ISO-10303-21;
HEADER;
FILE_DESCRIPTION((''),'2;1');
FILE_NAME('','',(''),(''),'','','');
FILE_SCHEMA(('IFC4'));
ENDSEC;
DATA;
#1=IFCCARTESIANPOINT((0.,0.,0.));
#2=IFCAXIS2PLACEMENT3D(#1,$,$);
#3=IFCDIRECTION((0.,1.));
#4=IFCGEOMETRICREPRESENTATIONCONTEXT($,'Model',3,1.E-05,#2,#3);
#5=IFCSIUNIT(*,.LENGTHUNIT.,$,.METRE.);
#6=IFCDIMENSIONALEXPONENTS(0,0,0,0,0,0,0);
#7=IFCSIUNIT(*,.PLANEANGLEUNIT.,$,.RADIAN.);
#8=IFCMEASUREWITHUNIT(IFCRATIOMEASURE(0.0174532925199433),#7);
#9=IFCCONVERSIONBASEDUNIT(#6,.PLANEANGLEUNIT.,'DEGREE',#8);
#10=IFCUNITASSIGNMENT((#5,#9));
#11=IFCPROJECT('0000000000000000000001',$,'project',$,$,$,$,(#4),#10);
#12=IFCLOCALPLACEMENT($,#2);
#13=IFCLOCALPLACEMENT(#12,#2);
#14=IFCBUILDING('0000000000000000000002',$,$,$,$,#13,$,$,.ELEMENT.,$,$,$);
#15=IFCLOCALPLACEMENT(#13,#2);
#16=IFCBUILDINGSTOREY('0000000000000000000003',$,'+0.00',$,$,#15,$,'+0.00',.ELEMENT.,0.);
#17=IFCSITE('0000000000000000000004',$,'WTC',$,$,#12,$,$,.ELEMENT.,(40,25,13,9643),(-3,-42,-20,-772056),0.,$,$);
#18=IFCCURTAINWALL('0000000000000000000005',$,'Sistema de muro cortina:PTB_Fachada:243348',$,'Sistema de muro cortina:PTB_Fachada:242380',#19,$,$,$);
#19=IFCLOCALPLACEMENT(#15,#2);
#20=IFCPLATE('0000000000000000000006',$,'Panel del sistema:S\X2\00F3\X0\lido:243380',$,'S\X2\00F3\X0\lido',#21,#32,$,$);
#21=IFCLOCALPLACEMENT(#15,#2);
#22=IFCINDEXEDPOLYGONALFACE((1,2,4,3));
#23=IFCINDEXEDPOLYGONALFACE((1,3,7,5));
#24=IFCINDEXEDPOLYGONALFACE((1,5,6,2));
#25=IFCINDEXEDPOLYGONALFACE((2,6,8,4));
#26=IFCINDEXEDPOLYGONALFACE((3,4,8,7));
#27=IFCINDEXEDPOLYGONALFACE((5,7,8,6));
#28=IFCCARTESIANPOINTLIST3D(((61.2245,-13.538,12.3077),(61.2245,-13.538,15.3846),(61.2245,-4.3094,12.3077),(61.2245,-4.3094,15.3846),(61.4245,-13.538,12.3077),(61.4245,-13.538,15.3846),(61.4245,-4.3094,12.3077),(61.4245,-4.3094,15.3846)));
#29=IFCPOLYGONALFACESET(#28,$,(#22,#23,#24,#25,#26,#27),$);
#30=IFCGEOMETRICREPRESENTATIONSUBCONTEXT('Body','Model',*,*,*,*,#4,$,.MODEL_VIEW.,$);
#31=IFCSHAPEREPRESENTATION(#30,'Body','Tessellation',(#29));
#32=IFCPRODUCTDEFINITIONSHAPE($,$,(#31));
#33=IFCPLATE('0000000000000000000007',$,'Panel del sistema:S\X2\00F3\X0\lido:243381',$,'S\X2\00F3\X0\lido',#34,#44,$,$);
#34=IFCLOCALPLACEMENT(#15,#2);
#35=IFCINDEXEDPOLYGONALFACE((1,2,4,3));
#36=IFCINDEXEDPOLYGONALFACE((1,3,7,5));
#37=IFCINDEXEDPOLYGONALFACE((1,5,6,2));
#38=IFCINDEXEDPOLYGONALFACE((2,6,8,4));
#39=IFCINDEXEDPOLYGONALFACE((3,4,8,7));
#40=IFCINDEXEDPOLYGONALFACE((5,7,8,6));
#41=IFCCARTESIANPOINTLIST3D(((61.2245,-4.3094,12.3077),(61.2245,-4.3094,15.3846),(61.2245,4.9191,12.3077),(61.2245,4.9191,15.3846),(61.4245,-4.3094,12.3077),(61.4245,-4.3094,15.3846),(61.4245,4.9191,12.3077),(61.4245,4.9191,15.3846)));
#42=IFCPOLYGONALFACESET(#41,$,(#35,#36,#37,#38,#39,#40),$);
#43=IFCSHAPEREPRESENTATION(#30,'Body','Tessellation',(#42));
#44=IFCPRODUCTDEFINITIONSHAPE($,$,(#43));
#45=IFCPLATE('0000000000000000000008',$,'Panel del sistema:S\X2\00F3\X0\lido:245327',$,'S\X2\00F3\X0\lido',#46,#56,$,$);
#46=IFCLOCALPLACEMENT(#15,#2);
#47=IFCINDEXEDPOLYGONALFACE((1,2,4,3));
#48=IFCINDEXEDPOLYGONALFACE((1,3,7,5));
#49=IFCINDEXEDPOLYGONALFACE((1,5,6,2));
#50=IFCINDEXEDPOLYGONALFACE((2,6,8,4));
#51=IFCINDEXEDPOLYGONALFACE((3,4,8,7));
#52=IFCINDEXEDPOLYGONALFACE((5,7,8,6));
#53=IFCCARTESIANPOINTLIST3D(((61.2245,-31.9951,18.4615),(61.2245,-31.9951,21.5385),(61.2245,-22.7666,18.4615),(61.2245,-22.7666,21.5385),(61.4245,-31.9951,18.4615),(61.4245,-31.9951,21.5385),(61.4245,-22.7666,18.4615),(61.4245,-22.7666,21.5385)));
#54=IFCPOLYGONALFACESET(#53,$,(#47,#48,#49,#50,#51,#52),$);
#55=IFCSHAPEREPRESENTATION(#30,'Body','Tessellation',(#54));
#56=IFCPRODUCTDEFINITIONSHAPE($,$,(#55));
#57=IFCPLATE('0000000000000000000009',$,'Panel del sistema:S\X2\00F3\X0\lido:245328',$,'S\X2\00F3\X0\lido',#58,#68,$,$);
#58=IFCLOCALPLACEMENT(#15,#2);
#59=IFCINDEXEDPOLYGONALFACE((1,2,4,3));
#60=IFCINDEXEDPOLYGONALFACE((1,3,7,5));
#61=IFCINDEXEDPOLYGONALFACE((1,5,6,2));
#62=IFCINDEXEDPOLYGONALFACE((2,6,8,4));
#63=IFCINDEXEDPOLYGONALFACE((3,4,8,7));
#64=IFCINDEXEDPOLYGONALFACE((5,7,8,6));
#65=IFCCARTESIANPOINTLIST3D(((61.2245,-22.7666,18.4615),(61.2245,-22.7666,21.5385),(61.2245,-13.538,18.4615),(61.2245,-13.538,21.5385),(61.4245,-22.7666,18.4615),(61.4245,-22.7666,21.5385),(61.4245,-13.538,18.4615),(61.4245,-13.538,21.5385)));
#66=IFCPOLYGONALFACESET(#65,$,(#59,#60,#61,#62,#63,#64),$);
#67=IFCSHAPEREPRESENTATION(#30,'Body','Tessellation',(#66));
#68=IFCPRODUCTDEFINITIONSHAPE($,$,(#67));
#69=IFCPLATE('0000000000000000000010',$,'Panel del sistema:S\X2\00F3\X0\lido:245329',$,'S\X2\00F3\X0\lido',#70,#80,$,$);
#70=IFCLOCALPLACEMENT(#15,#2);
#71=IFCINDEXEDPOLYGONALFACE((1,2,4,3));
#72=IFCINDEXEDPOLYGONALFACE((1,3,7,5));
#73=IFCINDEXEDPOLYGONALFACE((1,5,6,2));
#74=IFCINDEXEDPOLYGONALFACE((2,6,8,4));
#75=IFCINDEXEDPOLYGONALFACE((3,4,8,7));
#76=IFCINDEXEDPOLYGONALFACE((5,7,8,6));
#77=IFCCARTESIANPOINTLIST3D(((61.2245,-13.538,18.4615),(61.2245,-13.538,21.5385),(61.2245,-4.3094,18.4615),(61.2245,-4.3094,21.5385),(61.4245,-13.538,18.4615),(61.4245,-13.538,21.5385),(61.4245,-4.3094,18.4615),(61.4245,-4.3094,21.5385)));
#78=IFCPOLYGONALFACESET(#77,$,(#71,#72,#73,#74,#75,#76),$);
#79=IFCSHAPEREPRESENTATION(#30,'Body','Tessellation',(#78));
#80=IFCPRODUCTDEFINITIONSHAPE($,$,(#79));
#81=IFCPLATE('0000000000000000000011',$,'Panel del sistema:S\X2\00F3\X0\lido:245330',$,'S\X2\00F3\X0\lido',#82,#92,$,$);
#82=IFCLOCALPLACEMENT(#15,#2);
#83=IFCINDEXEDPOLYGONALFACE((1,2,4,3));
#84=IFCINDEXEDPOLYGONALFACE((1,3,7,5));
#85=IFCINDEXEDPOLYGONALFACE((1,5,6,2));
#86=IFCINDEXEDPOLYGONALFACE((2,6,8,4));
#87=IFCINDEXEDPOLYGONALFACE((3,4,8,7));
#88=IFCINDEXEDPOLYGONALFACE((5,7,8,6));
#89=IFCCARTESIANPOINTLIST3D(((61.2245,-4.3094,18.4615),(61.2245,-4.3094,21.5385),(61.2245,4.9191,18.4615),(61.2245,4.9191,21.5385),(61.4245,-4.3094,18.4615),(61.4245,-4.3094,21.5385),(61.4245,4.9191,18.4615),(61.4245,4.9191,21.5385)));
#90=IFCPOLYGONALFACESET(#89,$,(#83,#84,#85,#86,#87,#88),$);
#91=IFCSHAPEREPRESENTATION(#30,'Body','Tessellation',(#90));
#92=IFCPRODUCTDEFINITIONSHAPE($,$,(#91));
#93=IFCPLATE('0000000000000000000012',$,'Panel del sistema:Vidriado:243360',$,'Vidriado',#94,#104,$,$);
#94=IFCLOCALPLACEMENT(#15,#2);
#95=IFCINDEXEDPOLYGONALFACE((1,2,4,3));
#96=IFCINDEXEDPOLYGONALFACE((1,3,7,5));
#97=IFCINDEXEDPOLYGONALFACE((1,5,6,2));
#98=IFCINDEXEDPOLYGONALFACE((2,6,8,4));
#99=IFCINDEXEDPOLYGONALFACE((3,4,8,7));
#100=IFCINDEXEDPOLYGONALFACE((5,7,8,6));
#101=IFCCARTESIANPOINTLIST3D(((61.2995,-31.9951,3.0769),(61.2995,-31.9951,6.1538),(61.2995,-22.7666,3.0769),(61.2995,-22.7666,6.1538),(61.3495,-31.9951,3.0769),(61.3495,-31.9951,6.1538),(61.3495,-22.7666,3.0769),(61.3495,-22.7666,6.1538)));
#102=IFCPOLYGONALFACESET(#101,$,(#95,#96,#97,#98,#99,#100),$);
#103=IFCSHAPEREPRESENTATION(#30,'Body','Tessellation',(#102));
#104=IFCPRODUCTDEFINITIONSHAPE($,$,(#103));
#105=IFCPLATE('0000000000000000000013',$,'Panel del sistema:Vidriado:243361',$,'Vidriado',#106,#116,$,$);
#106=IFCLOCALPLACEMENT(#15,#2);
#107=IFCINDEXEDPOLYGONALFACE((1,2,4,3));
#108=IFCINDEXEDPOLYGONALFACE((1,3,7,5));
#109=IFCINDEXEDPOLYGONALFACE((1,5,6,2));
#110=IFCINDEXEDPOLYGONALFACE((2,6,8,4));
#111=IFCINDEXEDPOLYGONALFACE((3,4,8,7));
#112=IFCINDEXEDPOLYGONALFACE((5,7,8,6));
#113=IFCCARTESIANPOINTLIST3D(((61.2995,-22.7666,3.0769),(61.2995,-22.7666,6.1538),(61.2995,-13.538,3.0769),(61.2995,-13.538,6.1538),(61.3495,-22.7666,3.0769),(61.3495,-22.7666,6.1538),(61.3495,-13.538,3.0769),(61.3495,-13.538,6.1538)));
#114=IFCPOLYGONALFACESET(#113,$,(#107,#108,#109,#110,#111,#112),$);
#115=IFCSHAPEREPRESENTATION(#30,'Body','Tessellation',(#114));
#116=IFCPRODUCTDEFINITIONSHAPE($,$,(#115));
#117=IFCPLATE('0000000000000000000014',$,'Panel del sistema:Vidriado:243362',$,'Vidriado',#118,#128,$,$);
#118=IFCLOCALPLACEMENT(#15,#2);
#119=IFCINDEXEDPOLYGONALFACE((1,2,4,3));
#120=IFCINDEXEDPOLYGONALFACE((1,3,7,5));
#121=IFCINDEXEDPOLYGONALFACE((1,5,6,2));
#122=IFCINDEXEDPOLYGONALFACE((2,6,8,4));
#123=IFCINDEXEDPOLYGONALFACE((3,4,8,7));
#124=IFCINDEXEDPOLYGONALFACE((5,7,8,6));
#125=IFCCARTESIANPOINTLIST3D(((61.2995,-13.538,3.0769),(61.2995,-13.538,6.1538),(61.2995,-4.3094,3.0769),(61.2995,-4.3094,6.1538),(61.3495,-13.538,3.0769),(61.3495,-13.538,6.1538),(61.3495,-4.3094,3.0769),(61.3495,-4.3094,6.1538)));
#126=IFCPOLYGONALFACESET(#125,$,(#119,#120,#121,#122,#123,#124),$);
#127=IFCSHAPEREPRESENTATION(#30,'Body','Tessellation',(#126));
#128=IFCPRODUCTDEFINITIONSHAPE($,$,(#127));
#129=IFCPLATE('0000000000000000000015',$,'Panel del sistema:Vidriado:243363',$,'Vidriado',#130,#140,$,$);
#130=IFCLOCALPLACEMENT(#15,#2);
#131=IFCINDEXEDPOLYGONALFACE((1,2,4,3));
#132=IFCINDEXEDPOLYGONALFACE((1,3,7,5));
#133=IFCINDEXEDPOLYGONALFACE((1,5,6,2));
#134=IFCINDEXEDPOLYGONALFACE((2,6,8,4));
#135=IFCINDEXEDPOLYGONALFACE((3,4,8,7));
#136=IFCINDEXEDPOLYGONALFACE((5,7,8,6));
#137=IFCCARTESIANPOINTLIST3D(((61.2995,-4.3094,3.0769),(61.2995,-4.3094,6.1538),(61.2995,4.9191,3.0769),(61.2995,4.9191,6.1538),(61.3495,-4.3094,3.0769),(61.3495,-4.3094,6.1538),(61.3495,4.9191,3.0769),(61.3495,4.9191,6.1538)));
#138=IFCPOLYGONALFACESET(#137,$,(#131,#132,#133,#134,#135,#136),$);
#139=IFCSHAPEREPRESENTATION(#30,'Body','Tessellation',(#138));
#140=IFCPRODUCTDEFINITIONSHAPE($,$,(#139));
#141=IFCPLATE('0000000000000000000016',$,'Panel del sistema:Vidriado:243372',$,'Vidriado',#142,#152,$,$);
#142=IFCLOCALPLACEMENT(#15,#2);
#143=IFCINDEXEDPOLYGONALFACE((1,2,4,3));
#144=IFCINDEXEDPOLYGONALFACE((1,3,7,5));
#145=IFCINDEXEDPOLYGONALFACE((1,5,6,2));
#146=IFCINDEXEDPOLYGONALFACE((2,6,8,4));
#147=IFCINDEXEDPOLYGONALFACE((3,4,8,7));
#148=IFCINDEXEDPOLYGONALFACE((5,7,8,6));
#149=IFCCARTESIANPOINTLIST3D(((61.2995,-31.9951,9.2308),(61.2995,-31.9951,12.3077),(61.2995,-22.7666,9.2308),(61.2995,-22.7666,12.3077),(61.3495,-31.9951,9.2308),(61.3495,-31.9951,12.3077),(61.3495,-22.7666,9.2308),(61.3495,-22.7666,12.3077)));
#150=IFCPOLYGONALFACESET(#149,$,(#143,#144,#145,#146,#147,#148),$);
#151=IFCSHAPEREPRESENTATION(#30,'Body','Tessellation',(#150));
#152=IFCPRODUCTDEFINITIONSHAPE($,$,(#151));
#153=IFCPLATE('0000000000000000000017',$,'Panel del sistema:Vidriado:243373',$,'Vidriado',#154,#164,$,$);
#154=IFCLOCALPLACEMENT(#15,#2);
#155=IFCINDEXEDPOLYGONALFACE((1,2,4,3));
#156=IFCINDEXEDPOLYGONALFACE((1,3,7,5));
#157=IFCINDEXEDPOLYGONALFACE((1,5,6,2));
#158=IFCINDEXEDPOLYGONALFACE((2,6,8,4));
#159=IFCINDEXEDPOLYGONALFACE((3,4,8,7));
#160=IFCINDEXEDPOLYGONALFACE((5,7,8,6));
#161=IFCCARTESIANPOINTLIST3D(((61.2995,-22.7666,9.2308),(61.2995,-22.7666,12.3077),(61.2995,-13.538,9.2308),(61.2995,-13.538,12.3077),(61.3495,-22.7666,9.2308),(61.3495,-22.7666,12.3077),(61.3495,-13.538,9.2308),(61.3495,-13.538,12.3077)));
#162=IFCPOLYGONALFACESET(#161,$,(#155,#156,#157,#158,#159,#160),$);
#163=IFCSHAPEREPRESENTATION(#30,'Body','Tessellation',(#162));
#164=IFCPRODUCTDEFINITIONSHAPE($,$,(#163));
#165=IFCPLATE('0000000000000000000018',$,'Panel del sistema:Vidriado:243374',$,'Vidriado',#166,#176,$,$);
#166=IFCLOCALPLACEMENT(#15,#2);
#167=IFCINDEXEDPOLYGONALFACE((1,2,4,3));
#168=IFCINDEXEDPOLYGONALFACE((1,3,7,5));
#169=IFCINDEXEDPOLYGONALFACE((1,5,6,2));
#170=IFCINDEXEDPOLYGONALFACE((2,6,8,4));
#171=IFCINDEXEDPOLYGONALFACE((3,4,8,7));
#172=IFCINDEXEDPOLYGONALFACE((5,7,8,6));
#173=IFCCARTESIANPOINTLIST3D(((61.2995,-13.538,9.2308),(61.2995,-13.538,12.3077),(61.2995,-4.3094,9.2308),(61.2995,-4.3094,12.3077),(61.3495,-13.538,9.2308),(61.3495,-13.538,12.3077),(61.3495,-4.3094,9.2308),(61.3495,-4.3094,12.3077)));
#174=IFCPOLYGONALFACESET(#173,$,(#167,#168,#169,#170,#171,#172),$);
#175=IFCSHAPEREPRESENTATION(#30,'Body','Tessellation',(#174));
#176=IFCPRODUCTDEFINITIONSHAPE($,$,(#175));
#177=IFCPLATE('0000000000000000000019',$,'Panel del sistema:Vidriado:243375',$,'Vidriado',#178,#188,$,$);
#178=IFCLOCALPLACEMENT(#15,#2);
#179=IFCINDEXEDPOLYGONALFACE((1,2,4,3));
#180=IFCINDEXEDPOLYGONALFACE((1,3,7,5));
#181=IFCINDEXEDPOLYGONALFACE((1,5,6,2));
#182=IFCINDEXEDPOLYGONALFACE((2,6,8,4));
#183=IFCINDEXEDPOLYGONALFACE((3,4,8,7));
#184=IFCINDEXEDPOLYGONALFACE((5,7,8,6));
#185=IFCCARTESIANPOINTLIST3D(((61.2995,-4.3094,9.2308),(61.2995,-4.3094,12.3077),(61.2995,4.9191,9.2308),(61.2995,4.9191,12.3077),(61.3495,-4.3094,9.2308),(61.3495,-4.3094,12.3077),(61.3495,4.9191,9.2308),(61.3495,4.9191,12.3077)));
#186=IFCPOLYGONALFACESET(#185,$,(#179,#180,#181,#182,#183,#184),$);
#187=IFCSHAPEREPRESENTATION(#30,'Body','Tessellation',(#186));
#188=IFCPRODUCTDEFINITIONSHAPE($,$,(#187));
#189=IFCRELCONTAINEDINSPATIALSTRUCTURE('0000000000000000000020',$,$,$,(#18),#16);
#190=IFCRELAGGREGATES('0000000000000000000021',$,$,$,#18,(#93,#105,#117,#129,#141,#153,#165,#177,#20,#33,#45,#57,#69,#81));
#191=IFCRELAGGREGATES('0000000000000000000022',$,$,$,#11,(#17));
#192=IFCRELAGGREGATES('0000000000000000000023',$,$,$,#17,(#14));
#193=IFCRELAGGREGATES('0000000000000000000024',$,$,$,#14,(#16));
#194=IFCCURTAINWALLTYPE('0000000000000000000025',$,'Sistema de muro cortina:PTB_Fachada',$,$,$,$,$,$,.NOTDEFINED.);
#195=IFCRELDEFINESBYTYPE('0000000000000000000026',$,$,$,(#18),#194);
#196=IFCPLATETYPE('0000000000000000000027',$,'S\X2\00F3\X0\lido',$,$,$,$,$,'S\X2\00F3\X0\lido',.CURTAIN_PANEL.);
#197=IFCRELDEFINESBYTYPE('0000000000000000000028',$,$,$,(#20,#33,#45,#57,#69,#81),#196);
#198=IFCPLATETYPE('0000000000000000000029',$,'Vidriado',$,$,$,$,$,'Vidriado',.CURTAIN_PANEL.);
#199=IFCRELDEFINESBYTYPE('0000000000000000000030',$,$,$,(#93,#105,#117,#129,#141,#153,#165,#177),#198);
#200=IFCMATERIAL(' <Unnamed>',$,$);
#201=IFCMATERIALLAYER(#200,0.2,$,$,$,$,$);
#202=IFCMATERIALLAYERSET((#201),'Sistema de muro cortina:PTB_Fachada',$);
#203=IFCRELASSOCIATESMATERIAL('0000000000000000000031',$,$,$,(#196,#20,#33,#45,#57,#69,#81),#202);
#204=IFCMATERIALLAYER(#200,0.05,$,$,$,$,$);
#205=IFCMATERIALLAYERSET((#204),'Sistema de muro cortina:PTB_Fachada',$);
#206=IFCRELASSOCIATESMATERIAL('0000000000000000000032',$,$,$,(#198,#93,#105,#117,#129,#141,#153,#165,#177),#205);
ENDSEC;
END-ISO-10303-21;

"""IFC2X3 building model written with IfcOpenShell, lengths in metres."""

from ifc_helpers import new_model, entity, si_unit, converted_unit, direction, frame, frame_2d, origin, origin_2d_with_axis, place, context, subcontext, project, spatial, rectangle, extrude, source, transform, mapped, material, layer, layer_set, layer_usage, type_object, type_shapes, element, aggregate, save


model = new_model("IFC2X3")

# Units and contexts
model_context = context("Model", 3, precision=1e-05, world=origin(), true_north=direction((0.0, 1.0)))
body_context = subcontext(model_context, "Body", "Model", "MODEL_VIEW")
ifc_project = project(units=[si_unit("LENGTHUNIT", "METRE"), converted_unit("PLANEANGLEUNIT", "DEGREE", entity("IfcRatioMeasure", 0.0174532925199433), si_unit("PLANEANGLEUNIT", "RADIAN"), dimensions=[0, 0, 0, 0, 0, 0, 0])], contexts=[model_context])

# Site, building, storey
site_placement = place(None, origin())
site = spatial("IfcSite", under=ifc_project, at=site_placement, Name="WTC", CompositionType="ELEMENT", RefLatitude=(40, 25, 13, 9643), RefLongitude=(-3, -42, -20, -772056), RefElevation=0.0)
building_placement = place(site_placement, origin())
building = spatial("IfcBuilding", under=site, at=building_placement, CompositionType="ELEMENT")
storey_placement = place(building_placement, origin())
storey = spatial("IfcBuildingStorey", under=building, at=storey_placement, Name="+0.00", LongName="+0.00", CompositionType="ELEMENT", Elevation=0.0)

# Curtain wall, plates
curtain_wall_type = type_object("IfcCurtainWallType", Name="Sistema de muro cortina:PTB_Fachada", PredefinedType="NOTDEFINED")
ifc_material_1 = material(Name=" <Unnamed>")
ifc_layer_1 = layer(ifc_material_1, 0.2)
ifc_layer_set_1 = layer_set([ifc_layer_1], Name="Sistema de muro cortina:PTB_Fachada")
ifc_layer_2 = layer(ifc_material_1, 0.05)
ifc_layer_set_2 = layer_set([ifc_layer_2], Name="Sistema de muro cortina:PTB_Fachada")
curtain_wall_1_placement = place(storey_placement, origin())
curtain_wall_1 = element("IfcCurtainWall", 1, at=curtain_wall_1_placement, inside=storey, type_object=curtain_wall_type, Name="Sistema de muro cortina:PTB_Fachada:243348", ObjectType="Sistema de muro cortina:PTB_Fachada:242380")
plate_type_1 = type_object("IfcPlateType", Name="Sólido", ElementType="Sólido", PredefinedType="CURTAIN_PANEL", material=ifc_layer_set_1)
shared_shape_1 = source(origin(), body_context, "Body", "SweptSolid", [
    extrude(rectangle(XDim=0.2, YDim=9.2286, at=frame_2d((0.0, 0.0), x_axis=(1.0, 0.0))), frame((0.0, 0.0, 0.0), z_axis=(0.0, 0.0, 1.0), x_axis=(0.0, 1.0, 0.0)), (0.0, 0.0, 1.0), 3.0769),
])
type_shapes(plate_type_1, [shared_shape_1])
ifc_layer_usage_1 = layer_usage(ifc_layer_set_1, "AXIS3", "POSITIVE", 0.0)
plate_1_placement = place(curtain_wall_1_placement, frame((61.3245, -8.9237, 12.3077), z_axis=(0.0, 0.0, 1.0), x_axis=(0.0, 1.0, 0.0)))
plate_1 = element("IfcPlate", 2, at=plate_1_placement, type_object=plate_type_1, material=ifc_layer_usage_1, Name="Panel del sistema:Sólido:243380", ObjectType="Sólido", context=body_context, shape_type="MappedRepresentation", body=[
    mapped(shared_shape_1, transform((0.0, 0.0, 0.0), scale=1.0)),
])
ifc_layer_usage_2 = layer_usage(ifc_layer_set_1, "AXIS3", "POSITIVE", 0.0)
plate_2_placement = place(curtain_wall_1_placement, frame((61.3245, 0.3049, 12.3077), z_axis=(0.0, 0.0, 1.0), x_axis=(0.0, 1.0, 0.0)))
plate_2 = element("IfcPlate", 3, at=plate_2_placement, type_object=plate_type_1, material=ifc_layer_usage_2, Name="Panel del sistema:Sólido:243381", ObjectType="Sólido", context=body_context, shape_type="MappedRepresentation", body=[
    mapped(shared_shape_1, transform((0.0, 0.0, 0.0), scale=1.0)),
])
ifc_layer_usage_3 = layer_usage(ifc_layer_set_1, "AXIS3", "POSITIVE", 0.0)
plate_3_placement = place(curtain_wall_1_placement, frame((61.3245, -27.3809, 18.4615), z_axis=(0.0, 0.0, 1.0), x_axis=(0.0, 1.0, 0.0)))
plate_3 = element("IfcPlate", 4, at=plate_3_placement, type_object=plate_type_1, material=ifc_layer_usage_3, Name="Panel del sistema:Sólido:245327", ObjectType="Sólido", context=body_context, shape_type="MappedRepresentation", body=[
    mapped(shared_shape_1, transform((0.0, 0.0, 0.0), scale=1.0)),
])
ifc_layer_usage_4 = layer_usage(ifc_layer_set_1, "AXIS3", "POSITIVE", 0.0)
plate_4_placement = place(curtain_wall_1_placement, frame((61.3245, -18.1523, 18.4615), z_axis=(0.0, 0.0, 1.0), x_axis=(0.0, 1.0, 0.0)))
plate_4 = element("IfcPlate", 5, at=plate_4_placement, type_object=plate_type_1, material=ifc_layer_usage_4, Name="Panel del sistema:Sólido:245328", ObjectType="Sólido", context=body_context, shape_type="MappedRepresentation", body=[
    mapped(shared_shape_1, transform((0.0, 0.0, 0.0), scale=1.0)),
])
ifc_layer_usage_5 = layer_usage(ifc_layer_set_1, "AXIS3", "POSITIVE", 0.0)
plate_5_placement = place(curtain_wall_1_placement, frame((61.3245, -8.9237, 18.4615), z_axis=(0.0, 0.0, 1.0), x_axis=(0.0, 1.0, 0.0)))
plate_5 = element("IfcPlate", 6, at=plate_5_placement, type_object=plate_type_1, material=ifc_layer_usage_5, Name="Panel del sistema:Sólido:245329", ObjectType="Sólido", context=body_context, shape_type="MappedRepresentation", body=[
    mapped(shared_shape_1, transform((0.0, 0.0, 0.0), scale=1.0)),
])
ifc_layer_usage_6 = layer_usage(ifc_layer_set_1, "AXIS3", "POSITIVE", 0.0)
plate_6_placement = place(curtain_wall_1_placement, frame((61.3245, 0.3049, 18.4615), z_axis=(0.0, 0.0, 1.0), x_axis=(0.0, 1.0, 0.0)))
plate_6 = element("IfcPlate", 7, at=plate_6_placement, type_object=plate_type_1, material=ifc_layer_usage_6, Name="Panel del sistema:Sólido:245330", ObjectType="Sólido", context=body_context, shape_type="MappedRepresentation", body=[
    mapped(shared_shape_1, transform((0.0, 0.0, 0.0), scale=1.0)),
])
ifc_layer_usage_7 = layer_usage(ifc_layer_set_2, "AXIS3", "POSITIVE", 0.0)
plate_type_2 = type_object("IfcPlateType", Name="Vidriado", ElementType="Vidriado", PredefinedType="CURTAIN_PANEL", material=ifc_layer_set_2)
shared_shape_2 = source(origin(), body_context, "Body", "SweptSolid", [
    extrude(rectangle(XDim=0.05, YDim=9.2286, at=origin_2d_with_axis()), frame((0.0, 0.0, 0.0), z_axis=(0.0, 0.0, 1.0), x_axis=(0.0, 1.0, 0.0)), (0.0, 0.0, 1.0), 3.0769),
])
type_shapes(plate_type_2, [shared_shape_2])
plate_7_placement = place(curtain_wall_1_placement, frame((61.3245, -27.3809, 3.0769), z_axis=(0.0, 0.0, 1.0), x_axis=(0.0, 1.0, 0.0)))
plate_7 = element("IfcPlate", 8, at=plate_7_placement, type_object=plate_type_2, material=ifc_layer_usage_7, Name="Panel del sistema:Vidriado:243360", ObjectType="Vidriado", context=body_context, shape_type="MappedRepresentation", body=[
    mapped(shared_shape_2, transform((0.0, 0.0, 0.0), scale=1.0)),
])
ifc_layer_usage_8 = layer_usage(ifc_layer_set_2, "AXIS3", "POSITIVE", 0.0)
plate_8_placement = place(curtain_wall_1_placement, frame((61.3245, -18.1523, 3.0769), z_axis=(0.0, 0.0, 1.0), x_axis=(0.0, 1.0, 0.0)))
plate_8 = element("IfcPlate", 9, at=plate_8_placement, type_object=plate_type_2, material=ifc_layer_usage_8, Name="Panel del sistema:Vidriado:243361", ObjectType="Vidriado", context=body_context, shape_type="MappedRepresentation", body=[
    mapped(shared_shape_2, transform((0.0, 0.0, 0.0), scale=1.0)),
])
ifc_layer_usage_9 = layer_usage(ifc_layer_set_2, "AXIS3", "POSITIVE", 0.0)
plate_9_placement = place(curtain_wall_1_placement, frame((61.3245, -8.9237, 3.0769), z_axis=(0.0, 0.0, 1.0), x_axis=(0.0, 1.0, 0.0)))
plate_9 = element("IfcPlate", 10, at=plate_9_placement, type_object=plate_type_2, material=ifc_layer_usage_9, Name="Panel del sistema:Vidriado:243362", ObjectType="Vidriado", context=body_context, shape_type="MappedRepresentation", body=[
    mapped(shared_shape_2, transform((0.0, 0.0, 0.0), scale=1.0)),
])
ifc_layer_usage_10 = layer_usage(ifc_layer_set_2, "AXIS3", "POSITIVE", 0.0)
plate_10_placement = place(curtain_wall_1_placement, frame((61.3245, 0.3049, 3.0769), z_axis=(0.0, 0.0, 1.0), x_axis=(0.0, 1.0, 0.0)))
plate_10 = element("IfcPlate", 11, at=plate_10_placement, type_object=plate_type_2, material=ifc_layer_usage_10, Name="Panel del sistema:Vidriado:243363", ObjectType="Vidriado", context=body_context, shape_type="MappedRepresentation", body=[
    mapped(shared_shape_2, transform((0.0, 0.0, 0.0), scale=1.0)),
])
ifc_layer_usage_11 = layer_usage(ifc_layer_set_2, "AXIS3", "POSITIVE", 0.0)
plate_11_placement = place(curtain_wall_1_placement, frame((61.3245, -27.3809, 9.2308), z_axis=(0.0, 0.0, 1.0), x_axis=(0.0, 1.0, 0.0)))
plate_11 = element("IfcPlate", 12, at=plate_11_placement, type_object=plate_type_2, material=ifc_layer_usage_11, Name="Panel del sistema:Vidriado:243372", ObjectType="Vidriado", context=body_context, shape_type="MappedRepresentation", body=[
    mapped(shared_shape_2, transform((0.0, 0.0, 0.0), scale=1.0)),
])
ifc_layer_usage_12 = layer_usage(ifc_layer_set_2, "AXIS3", "POSITIVE", 0.0)
plate_12_placement = place(curtain_wall_1_placement, frame((61.3245, -18.1523, 9.2308), z_axis=(0.0, 0.0, 1.0), x_axis=(0.0, 1.0, 0.0)))
plate_12 = element("IfcPlate", 13, at=plate_12_placement, type_object=plate_type_2, material=ifc_layer_usage_12, Name="Panel del sistema:Vidriado:243373", ObjectType="Vidriado", context=body_context, shape_type="MappedRepresentation", body=[
    mapped(shared_shape_2, transform((0.0, 0.0, 0.0), scale=1.0)),
])
ifc_layer_usage_13 = layer_usage(ifc_layer_set_2, "AXIS3", "POSITIVE", 0.0)
plate_13_placement = place(curtain_wall_1_placement, frame((61.3245, -8.9237, 9.2308), z_axis=(0.0, 0.0, 1.0), x_axis=(0.0, 1.0, 0.0)))
plate_13 = element("IfcPlate", 14, at=plate_13_placement, type_object=plate_type_2, material=ifc_layer_usage_13, Name="Panel del sistema:Vidriado:243374", ObjectType="Vidriado", context=body_context, shape_type="MappedRepresentation", body=[
    mapped(shared_shape_2, transform((0.0, 0.0, 0.0), scale=1.0)),
])
ifc_layer_usage_14 = layer_usage(ifc_layer_set_2, "AXIS3", "POSITIVE", 0.0)
plate_14_placement = place(curtain_wall_1_placement, frame((61.3245, 0.3049, 9.2308), z_axis=(0.0, 0.0, 1.0), x_axis=(0.0, 1.0, 0.0)))
plate_14 = element("IfcPlate", 15, at=plate_14_placement, type_object=plate_type_2, material=ifc_layer_usage_14, Name="Panel del sistema:Vidriado:243375", ObjectType="Vidriado", context=body_context, shape_type="MappedRepresentation", body=[
    mapped(shared_shape_2, transform((0.0, 0.0, 0.0), scale=1.0)),
])
aggregate(curtain_wall_1, [plate_7, plate_8, plate_9, plate_10, plate_11, plate_12, plate_13, plate_14, plate_1, plate_2, plate_3, plate_4, plate_5, plate_6])

save(model, "model.ifc")
